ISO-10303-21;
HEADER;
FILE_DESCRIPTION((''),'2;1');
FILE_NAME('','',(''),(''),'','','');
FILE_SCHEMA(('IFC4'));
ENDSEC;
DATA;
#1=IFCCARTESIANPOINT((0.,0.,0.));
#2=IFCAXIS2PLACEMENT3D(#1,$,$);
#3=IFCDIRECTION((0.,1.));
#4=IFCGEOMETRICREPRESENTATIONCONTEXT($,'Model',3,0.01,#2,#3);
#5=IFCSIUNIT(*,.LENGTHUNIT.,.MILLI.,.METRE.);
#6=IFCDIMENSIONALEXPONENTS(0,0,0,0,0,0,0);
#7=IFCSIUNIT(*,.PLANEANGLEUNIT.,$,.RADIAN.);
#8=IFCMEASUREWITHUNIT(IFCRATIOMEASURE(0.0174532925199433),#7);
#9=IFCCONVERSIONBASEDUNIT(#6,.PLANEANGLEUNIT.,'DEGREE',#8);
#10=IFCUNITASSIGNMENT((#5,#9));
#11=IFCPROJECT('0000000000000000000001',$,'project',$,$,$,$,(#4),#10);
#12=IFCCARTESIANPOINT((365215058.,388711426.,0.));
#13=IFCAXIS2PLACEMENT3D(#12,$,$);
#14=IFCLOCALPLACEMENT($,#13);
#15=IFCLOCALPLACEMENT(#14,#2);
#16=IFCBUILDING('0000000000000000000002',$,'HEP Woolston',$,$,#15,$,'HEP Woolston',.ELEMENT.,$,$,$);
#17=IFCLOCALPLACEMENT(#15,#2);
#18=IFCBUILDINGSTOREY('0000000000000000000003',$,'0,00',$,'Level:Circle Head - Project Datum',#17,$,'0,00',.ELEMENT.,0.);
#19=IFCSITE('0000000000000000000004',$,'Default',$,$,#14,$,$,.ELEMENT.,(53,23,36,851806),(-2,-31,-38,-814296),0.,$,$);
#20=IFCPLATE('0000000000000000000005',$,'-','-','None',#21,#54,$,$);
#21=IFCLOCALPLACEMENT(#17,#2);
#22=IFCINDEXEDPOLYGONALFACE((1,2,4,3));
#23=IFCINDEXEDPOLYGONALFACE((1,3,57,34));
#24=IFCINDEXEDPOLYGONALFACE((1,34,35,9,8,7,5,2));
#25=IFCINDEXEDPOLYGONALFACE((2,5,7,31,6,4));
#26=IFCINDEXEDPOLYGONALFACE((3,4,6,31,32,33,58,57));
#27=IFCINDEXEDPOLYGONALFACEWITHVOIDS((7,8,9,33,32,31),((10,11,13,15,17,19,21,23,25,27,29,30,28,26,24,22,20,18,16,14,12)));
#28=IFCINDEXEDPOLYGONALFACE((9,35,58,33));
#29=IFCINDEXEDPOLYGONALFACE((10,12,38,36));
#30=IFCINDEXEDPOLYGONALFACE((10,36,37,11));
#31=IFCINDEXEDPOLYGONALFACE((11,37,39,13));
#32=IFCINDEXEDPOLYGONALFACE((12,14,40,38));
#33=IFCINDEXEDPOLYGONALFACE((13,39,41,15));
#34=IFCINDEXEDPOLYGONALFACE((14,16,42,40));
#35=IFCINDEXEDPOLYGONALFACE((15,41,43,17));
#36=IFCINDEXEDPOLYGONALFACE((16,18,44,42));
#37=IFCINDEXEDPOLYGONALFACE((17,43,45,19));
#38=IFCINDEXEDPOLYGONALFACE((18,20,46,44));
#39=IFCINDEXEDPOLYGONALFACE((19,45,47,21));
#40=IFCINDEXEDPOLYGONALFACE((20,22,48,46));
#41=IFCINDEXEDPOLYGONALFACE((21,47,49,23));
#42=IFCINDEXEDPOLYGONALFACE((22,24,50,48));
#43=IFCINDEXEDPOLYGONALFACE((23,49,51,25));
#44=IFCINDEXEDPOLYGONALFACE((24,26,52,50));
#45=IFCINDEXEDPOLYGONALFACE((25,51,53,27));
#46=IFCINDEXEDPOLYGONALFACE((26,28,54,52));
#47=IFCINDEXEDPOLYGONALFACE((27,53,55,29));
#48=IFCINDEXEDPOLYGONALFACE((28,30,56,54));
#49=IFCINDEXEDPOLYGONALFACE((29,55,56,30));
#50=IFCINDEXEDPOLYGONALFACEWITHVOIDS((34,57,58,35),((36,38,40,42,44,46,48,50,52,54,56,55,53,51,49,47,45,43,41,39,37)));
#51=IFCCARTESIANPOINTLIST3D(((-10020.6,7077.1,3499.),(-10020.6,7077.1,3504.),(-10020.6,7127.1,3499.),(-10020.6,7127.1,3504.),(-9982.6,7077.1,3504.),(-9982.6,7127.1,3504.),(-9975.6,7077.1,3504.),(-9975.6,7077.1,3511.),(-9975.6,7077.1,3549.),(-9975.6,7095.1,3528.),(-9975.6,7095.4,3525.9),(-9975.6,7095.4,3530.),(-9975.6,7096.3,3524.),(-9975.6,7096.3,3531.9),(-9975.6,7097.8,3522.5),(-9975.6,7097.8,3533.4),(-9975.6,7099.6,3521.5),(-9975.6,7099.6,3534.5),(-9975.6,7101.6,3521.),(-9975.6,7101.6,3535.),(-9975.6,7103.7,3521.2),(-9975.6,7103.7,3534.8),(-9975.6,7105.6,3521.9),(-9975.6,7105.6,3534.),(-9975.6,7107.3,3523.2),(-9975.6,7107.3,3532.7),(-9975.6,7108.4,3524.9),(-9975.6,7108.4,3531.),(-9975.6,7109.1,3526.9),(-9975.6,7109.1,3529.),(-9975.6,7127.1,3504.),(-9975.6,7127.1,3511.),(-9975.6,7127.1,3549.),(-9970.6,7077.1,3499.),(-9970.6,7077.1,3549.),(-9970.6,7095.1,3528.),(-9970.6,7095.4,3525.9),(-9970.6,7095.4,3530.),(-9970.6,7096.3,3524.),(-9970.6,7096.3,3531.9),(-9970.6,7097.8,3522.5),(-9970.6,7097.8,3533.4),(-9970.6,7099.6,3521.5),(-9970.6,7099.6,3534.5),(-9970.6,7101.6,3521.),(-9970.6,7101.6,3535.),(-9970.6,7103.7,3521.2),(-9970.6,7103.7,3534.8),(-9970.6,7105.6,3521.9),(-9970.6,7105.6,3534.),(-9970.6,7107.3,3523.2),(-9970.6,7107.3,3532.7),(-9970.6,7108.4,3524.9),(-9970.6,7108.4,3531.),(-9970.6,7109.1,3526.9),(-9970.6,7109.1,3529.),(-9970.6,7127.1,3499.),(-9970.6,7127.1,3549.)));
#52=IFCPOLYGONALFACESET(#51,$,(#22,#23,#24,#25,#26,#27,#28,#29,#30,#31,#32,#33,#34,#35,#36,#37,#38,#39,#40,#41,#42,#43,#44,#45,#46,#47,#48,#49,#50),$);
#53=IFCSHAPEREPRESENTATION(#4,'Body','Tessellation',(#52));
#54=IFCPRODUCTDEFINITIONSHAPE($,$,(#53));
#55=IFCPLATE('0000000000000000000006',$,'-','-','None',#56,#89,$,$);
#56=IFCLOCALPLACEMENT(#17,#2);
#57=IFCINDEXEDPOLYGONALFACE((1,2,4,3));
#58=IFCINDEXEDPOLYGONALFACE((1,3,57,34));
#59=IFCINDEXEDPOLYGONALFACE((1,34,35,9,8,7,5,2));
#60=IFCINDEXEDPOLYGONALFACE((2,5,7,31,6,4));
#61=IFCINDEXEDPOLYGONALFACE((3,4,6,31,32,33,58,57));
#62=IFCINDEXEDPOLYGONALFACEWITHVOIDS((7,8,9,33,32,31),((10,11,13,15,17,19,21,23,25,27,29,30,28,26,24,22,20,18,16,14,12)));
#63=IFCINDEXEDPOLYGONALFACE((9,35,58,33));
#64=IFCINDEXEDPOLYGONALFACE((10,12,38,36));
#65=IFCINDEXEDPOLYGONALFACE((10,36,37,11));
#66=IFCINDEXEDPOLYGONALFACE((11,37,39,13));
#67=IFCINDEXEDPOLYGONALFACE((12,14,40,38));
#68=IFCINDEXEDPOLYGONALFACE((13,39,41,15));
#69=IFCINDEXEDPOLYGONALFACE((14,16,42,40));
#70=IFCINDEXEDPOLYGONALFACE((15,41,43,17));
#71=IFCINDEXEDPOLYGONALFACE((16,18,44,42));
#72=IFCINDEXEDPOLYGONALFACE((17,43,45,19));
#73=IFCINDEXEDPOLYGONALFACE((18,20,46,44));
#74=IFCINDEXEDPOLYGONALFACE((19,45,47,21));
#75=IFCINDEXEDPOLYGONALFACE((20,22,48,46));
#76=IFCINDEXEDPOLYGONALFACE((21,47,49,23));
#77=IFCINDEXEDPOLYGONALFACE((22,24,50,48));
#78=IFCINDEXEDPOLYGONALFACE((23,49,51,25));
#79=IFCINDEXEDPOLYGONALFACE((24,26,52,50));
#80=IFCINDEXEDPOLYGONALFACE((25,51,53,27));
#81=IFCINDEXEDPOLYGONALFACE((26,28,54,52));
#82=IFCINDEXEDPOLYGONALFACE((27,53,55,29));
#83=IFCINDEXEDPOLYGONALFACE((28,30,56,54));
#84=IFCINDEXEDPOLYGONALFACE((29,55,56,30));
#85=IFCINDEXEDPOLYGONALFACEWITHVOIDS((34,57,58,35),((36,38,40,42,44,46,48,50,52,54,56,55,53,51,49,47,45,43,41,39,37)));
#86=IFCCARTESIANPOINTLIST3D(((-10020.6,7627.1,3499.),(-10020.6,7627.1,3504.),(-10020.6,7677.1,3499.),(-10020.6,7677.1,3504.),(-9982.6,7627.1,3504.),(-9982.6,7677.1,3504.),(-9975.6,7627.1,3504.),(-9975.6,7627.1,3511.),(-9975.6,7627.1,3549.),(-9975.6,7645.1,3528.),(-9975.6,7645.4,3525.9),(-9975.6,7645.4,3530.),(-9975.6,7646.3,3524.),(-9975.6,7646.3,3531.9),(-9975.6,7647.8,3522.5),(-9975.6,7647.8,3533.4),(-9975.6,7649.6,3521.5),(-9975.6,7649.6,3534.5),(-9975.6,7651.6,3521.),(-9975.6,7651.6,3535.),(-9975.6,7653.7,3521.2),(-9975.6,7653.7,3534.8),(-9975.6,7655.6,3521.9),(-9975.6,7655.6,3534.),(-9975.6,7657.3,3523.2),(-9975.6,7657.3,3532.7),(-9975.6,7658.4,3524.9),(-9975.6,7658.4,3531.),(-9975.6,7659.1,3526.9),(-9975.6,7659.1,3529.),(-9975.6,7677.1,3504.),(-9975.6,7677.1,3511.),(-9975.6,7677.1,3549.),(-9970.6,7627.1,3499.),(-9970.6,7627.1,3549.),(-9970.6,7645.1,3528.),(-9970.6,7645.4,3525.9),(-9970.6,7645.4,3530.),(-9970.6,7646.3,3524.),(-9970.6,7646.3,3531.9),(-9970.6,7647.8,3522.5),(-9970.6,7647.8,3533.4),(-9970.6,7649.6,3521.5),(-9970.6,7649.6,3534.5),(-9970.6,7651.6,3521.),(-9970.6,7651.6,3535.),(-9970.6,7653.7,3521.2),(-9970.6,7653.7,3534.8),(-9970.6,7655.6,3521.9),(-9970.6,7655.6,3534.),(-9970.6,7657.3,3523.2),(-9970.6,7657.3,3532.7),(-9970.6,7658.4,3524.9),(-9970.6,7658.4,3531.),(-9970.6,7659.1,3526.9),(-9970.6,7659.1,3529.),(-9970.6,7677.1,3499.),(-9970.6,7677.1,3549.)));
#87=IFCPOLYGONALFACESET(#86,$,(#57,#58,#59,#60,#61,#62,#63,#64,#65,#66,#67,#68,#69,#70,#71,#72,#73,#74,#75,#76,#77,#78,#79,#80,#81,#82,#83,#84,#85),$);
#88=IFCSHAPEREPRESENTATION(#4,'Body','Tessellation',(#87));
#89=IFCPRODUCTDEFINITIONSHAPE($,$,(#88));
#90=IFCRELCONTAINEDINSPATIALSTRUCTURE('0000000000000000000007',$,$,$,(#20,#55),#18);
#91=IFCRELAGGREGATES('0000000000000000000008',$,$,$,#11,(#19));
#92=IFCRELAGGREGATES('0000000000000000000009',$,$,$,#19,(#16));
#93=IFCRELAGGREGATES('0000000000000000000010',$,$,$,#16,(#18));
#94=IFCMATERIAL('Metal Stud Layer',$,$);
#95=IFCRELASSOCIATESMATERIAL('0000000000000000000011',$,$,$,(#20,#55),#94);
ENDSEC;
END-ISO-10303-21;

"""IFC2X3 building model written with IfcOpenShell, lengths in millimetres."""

from ifc_helpers import new_model, entity, si_unit, converted_unit, point, direction, frame, frame_2d, origin, origin_with_axes, origin_2d_with_axis, place, context, project, spatial, polyline, circle_curve, line_curve, trimmed, segment, composite_curve, circle, outline, extrude, material, element, save


model = new_model("IFC2X3")

# Units and contexts
model_context = context("Model", 3, precision=0.01, world=origin(), true_north=direction((0.0, 1.0)))
ifc_project = project(units=[si_unit("LENGTHUNIT", "METRE", prefix="MILLI"), converted_unit("PLANEANGLEUNIT", "DEGREE", entity("IfcRatioMeasure", 0.0174532925199433), si_unit("PLANEANGLEUNIT", "RADIAN"), dimensions=[0, 0, 0, 0, 0, 0, 0])], contexts=[model_context])

# Site, building, storey
site_placement = place(None, frame((365215058.0, 388711426.0, 0.0)))
site = spatial("IfcSite", under=ifc_project, at=site_placement, Name="Default", CompositionType="ELEMENT", RefLatitude=(53, 23, 36, 851806), RefLongitude=(-2, -31, -38, -814296), RefElevation=0.0)
building_placement = place(site_placement, origin())
building = spatial("IfcBuilding", under=site, at=building_placement, Name="HEP Woolston", LongName="HEP Woolston", CompositionType="ELEMENT")
storey_placement = place(building_placement, origin())
storey = spatial("IfcBuildingStorey", under=building, at=storey_placement, Name="0,00", ObjectType="Level:Circle Head - Project Datum", LongName="0,00", CompositionType="ELEMENT", Elevation=0.0)

# Plates, openings
ifc_material = material(Name="Metal Stud Layer")
plate_1_placement = place(storey_placement, frame((-9970.6, 7077.1, 3499.0), z_axis=(0.0, 1.0, 0.0), x_axis=(-1.0, 0.0, 0.0)))
plate_1 = element("IfcPlate", 1, at=plate_1_placement, inside=storey, material=ifc_material, Name="-", Description="-", ObjectType="None", context=model_context, shape_type="SweptSolid", body=[
    extrude(outline(polyline([(0.0, 0.0), (50.0, 0.0), (50.0, 5.0), (5.0, 5.0), (5.0, 50.0), (0.0, 50.0), (0.0, 0.0)])), origin_with_axes(), (0.0, 0.0, 1.0), 50.0),
])
opening_1_placement = place(plate_1_placement, frame((0.0, 0.0, 0.0), z_axis=(0.0, 0.0, 1.0), x_axis=(1.0, 0.0, 0.0)))
element("IfcOpeningElement", 2, at=opening_1_placement, cuts=plate_1, ObjectType="Opening", context=model_context, shape_type="SweptSolid", body=[
    extrude(outline(composite_curve([segment(trimmed(line_curve((50.0, 5.0), (1.0, 0.0), 3.532613), [point((50.0, 5.0))], [point((46.5, 5.0))], True, "CARTESIAN"), True, "CONTINUOUS"), segment(trimmed(circle_curve(frame_2d((46.5, 1.5), x_axis=(-1.0, 0.0)), 3.5), [point((46.5, 5.0))], [point((50.0, 1.5))], False, "CARTESIAN"), True, "CONTINUOUS"), segment(trimmed(line_curve((50.0, 1.5), (0.0, -1.0), 3.532613), [point((50.0, 1.5))], [point((50.0, 5.0))], True, "CARTESIAN"), True, "CONTINUOUS")], self_intersect="UNKNOWN")), origin(), (0.0, 0.0, 1.0), 50.0),
])
opening_2_placement = place(plate_1_placement, origin_with_axes())
element("IfcOpeningElement", 3, at=opening_2_placement, cuts=plate_1, ObjectType="Opening", context=model_context, shape_type="SweptSolid", body=[
    extrude(outline(composite_curve([segment(trimmed(line_curve((5.0, 5.0), (0.0, -1.0), 7.046301), [point((5.0, 5.0))], [point((5.0, 12.0))], False, "CARTESIAN"), True, "CONTINUOUS"), segment(trimmed(circle_curve(frame_2d((12.0, 12.0), x_axis=(1.0, 0.0)), 7.0), [point((5.0, 12.0))], [point((12.0, 5.0))], True, "CARTESIAN"), True, "CONTINUOUS"), segment(trimmed(line_curve((12.0, 5.0), (1.0, 0.0), 7.046301), [point((12.0, 5.0))], [point((5.0, 5.0))], False, "CARTESIAN"), True, "CONTINUOUS")], self_intersect="UNKNOWN")), origin(), (0.0, 0.0, 1.0), 50.0),
])
opening_3_placement = place(plate_1_placement, frame((0.0, 0.0, 0.0), z_axis=(0.0, 0.0, 1.0), x_axis=(1.0, 0.0, 0.0)))
element("IfcOpeningElement", 4, at=opening_3_placement, cuts=plate_1, ObjectType="Opening", context=model_context, shape_type="SweptSolid", body=[
    extrude(outline(composite_curve([segment(trimmed(line_curve((5.0, 50.0), (1.0, 0.0), 3.4874), [point((5.0, 50.0))], [point((1.5, 50.0))], True, "CARTESIAN"), True, "CONTINUOUS"), segment(trimmed(circle_curve(frame_2d((1.5, 46.5), x_axis=(-1.0, 0.0)), 3.5), [point((1.5, 50.0))], [point((5.0, 46.5))], False, "CARTESIAN"), True, "CONTINUOUS"), segment(trimmed(line_curve((5.0, 46.5), (0.0, -1.0), 3.4874), [point((5.0, 46.5))], [point((5.0, 50.0))], True, "CARTESIAN"), True, "CONTINUOUS")], self_intersect="UNKNOWN")), origin(), (0.0, 0.0, 1.0), 50.0),
])
opening_4_placement = place(plate_1_placement, frame((-0.5, 29.0, 25.0), z_axis=(1.0, 0.0, 0.0), x_axis=(0.0, 0.0, -1.0)))
element("IfcOpeningElement", 5, at=opening_4_placement, cuts=plate_1, ObjectType="Opening", context=model_context, shape_type="SweptSolid", body=[
    extrude(circle(Radius=7.0, at=origin_2d_with_axis()), origin(), (0.0, 0.0, 1.0), 6.0),
])
plate_2_placement = place(storey_placement, frame((-9970.6, 7627.1, 3499.0), z_axis=(0.0, 1.0, 0.0), x_axis=(-1.0, 0.0, 0.0)))
plate_2 = element("IfcPlate", 6, at=plate_2_placement, inside=storey, material=ifc_material, Name="-", Description="-", ObjectType="None", context=model_context, shape_type="SweptSolid", body=[
    extrude(outline(polyline([(0.0, 0.0), (50.0, 0.0), (50.0, 5.0), (5.0, 5.0), (5.0, 50.0), (0.0, 50.0), (0.0, 0.0)])), origin_with_axes(), (0.0, 0.0, 1.0), 50.0),
])
opening_5_placement = place(plate_2_placement, frame((0.0, 0.0, 0.0), z_axis=(0.0, 0.0, 1.0), x_axis=(1.0, 0.0, 0.0)))
element("IfcOpeningElement", 7, at=opening_5_placement, cuts=plate_2, ObjectType="Opening", context=model_context, shape_type="SweptSolid", body=[
    extrude(outline(composite_curve([segment(trimmed(line_curve((50.0, 5.0), (1.0, 0.0), 3.532613), [point((50.0, 5.0))], [point((46.5, 5.0))], True, "CARTESIAN"), True, "CONTINUOUS"), segment(trimmed(circle_curve(frame_2d((46.5, 1.5), x_axis=(-1.0, 0.0)), 3.5), [point((46.5, 5.0))], [point((50.0, 1.5))], False, "CARTESIAN"), True, "CONTINUOUS"), segment(trimmed(line_curve((50.0, 1.5), (0.0, -1.0), 3.532613), [point((50.0, 1.5))], [point((50.0, 5.0))], True, "CARTESIAN"), True, "CONTINUOUS")], self_intersect="UNKNOWN")), origin(), (0.0, 0.0, 1.0), 50.0),
])
opening_6_placement = place(plate_2_placement, origin_with_axes())
element("IfcOpeningElement", 8, at=opening_6_placement, cuts=plate_2, ObjectType="Opening", context=model_context, shape_type="SweptSolid", body=[
    extrude(outline(composite_curve([segment(trimmed(line_curve((5.0, 5.0), (0.0, -1.0), 7.046301), [point((5.0, 5.0))], [point((5.0, 12.0))], False, "CARTESIAN"), True, "CONTINUOUS"), segment(trimmed(circle_curve(frame_2d((12.0, 12.0), x_axis=(1.0, 0.0)), 7.0), [point((5.0, 12.0))], [point((12.0, 5.0))], True, "CARTESIAN"), True, "CONTINUOUS"), segment(trimmed(line_curve((12.0, 5.0), (1.0, 0.0), 7.046301), [point((12.0, 5.0))], [point((5.0, 5.0))], False, "CARTESIAN"), True, "CONTINUOUS")], self_intersect="UNKNOWN")), origin(), (0.0, 0.0, 1.0), 50.0),
])
opening_7_placement = place(plate_2_placement, frame((0.0, 0.0, 0.0), z_axis=(0.0, 0.0, 1.0), x_axis=(1.0, 0.0, 0.0)))
element("IfcOpeningElement", 9, at=opening_7_placement, cuts=plate_2, ObjectType="Opening", context=model_context, shape_type="SweptSolid", body=[
    extrude(outline(composite_curve([segment(trimmed(line_curve((5.0, 50.0), (1.0, 0.0), 3.4874), [point((5.0, 50.0))], [point((1.5, 50.0))], True, "CARTESIAN"), True, "CONTINUOUS"), segment(trimmed(circle_curve(frame_2d((1.5, 46.5), x_axis=(-1.0, 0.0)), 3.5), [point((1.5, 50.0))], [point((5.0, 46.5))], False, "CARTESIAN"), True, "CONTINUOUS"), segment(trimmed(line_curve((5.0, 46.5), (0.0, -1.0), 3.4874), [point((5.0, 46.5))], [point((5.0, 50.0))], True, "CARTESIAN"), True, "CONTINUOUS")], self_intersect="UNKNOWN")), origin(), (0.0, 0.0, 1.0), 50.0),
])
opening_8_placement = place(plate_2_placement, frame((-0.5, 29.0, 25.0), z_axis=(1.0, 0.0, 0.0), x_axis=(0.0, 0.0, -1.0)))
element("IfcOpeningElement", 10, at=opening_8_placement, cuts=plate_2, ObjectType="Opening", context=model_context, shape_type="SweptSolid", body=[
    extrude(circle(Radius=7.0, at=origin_2d_with_axis()), origin(), (0.0, 0.0, 1.0), 6.0),
])

save(model, "model.ifc")
